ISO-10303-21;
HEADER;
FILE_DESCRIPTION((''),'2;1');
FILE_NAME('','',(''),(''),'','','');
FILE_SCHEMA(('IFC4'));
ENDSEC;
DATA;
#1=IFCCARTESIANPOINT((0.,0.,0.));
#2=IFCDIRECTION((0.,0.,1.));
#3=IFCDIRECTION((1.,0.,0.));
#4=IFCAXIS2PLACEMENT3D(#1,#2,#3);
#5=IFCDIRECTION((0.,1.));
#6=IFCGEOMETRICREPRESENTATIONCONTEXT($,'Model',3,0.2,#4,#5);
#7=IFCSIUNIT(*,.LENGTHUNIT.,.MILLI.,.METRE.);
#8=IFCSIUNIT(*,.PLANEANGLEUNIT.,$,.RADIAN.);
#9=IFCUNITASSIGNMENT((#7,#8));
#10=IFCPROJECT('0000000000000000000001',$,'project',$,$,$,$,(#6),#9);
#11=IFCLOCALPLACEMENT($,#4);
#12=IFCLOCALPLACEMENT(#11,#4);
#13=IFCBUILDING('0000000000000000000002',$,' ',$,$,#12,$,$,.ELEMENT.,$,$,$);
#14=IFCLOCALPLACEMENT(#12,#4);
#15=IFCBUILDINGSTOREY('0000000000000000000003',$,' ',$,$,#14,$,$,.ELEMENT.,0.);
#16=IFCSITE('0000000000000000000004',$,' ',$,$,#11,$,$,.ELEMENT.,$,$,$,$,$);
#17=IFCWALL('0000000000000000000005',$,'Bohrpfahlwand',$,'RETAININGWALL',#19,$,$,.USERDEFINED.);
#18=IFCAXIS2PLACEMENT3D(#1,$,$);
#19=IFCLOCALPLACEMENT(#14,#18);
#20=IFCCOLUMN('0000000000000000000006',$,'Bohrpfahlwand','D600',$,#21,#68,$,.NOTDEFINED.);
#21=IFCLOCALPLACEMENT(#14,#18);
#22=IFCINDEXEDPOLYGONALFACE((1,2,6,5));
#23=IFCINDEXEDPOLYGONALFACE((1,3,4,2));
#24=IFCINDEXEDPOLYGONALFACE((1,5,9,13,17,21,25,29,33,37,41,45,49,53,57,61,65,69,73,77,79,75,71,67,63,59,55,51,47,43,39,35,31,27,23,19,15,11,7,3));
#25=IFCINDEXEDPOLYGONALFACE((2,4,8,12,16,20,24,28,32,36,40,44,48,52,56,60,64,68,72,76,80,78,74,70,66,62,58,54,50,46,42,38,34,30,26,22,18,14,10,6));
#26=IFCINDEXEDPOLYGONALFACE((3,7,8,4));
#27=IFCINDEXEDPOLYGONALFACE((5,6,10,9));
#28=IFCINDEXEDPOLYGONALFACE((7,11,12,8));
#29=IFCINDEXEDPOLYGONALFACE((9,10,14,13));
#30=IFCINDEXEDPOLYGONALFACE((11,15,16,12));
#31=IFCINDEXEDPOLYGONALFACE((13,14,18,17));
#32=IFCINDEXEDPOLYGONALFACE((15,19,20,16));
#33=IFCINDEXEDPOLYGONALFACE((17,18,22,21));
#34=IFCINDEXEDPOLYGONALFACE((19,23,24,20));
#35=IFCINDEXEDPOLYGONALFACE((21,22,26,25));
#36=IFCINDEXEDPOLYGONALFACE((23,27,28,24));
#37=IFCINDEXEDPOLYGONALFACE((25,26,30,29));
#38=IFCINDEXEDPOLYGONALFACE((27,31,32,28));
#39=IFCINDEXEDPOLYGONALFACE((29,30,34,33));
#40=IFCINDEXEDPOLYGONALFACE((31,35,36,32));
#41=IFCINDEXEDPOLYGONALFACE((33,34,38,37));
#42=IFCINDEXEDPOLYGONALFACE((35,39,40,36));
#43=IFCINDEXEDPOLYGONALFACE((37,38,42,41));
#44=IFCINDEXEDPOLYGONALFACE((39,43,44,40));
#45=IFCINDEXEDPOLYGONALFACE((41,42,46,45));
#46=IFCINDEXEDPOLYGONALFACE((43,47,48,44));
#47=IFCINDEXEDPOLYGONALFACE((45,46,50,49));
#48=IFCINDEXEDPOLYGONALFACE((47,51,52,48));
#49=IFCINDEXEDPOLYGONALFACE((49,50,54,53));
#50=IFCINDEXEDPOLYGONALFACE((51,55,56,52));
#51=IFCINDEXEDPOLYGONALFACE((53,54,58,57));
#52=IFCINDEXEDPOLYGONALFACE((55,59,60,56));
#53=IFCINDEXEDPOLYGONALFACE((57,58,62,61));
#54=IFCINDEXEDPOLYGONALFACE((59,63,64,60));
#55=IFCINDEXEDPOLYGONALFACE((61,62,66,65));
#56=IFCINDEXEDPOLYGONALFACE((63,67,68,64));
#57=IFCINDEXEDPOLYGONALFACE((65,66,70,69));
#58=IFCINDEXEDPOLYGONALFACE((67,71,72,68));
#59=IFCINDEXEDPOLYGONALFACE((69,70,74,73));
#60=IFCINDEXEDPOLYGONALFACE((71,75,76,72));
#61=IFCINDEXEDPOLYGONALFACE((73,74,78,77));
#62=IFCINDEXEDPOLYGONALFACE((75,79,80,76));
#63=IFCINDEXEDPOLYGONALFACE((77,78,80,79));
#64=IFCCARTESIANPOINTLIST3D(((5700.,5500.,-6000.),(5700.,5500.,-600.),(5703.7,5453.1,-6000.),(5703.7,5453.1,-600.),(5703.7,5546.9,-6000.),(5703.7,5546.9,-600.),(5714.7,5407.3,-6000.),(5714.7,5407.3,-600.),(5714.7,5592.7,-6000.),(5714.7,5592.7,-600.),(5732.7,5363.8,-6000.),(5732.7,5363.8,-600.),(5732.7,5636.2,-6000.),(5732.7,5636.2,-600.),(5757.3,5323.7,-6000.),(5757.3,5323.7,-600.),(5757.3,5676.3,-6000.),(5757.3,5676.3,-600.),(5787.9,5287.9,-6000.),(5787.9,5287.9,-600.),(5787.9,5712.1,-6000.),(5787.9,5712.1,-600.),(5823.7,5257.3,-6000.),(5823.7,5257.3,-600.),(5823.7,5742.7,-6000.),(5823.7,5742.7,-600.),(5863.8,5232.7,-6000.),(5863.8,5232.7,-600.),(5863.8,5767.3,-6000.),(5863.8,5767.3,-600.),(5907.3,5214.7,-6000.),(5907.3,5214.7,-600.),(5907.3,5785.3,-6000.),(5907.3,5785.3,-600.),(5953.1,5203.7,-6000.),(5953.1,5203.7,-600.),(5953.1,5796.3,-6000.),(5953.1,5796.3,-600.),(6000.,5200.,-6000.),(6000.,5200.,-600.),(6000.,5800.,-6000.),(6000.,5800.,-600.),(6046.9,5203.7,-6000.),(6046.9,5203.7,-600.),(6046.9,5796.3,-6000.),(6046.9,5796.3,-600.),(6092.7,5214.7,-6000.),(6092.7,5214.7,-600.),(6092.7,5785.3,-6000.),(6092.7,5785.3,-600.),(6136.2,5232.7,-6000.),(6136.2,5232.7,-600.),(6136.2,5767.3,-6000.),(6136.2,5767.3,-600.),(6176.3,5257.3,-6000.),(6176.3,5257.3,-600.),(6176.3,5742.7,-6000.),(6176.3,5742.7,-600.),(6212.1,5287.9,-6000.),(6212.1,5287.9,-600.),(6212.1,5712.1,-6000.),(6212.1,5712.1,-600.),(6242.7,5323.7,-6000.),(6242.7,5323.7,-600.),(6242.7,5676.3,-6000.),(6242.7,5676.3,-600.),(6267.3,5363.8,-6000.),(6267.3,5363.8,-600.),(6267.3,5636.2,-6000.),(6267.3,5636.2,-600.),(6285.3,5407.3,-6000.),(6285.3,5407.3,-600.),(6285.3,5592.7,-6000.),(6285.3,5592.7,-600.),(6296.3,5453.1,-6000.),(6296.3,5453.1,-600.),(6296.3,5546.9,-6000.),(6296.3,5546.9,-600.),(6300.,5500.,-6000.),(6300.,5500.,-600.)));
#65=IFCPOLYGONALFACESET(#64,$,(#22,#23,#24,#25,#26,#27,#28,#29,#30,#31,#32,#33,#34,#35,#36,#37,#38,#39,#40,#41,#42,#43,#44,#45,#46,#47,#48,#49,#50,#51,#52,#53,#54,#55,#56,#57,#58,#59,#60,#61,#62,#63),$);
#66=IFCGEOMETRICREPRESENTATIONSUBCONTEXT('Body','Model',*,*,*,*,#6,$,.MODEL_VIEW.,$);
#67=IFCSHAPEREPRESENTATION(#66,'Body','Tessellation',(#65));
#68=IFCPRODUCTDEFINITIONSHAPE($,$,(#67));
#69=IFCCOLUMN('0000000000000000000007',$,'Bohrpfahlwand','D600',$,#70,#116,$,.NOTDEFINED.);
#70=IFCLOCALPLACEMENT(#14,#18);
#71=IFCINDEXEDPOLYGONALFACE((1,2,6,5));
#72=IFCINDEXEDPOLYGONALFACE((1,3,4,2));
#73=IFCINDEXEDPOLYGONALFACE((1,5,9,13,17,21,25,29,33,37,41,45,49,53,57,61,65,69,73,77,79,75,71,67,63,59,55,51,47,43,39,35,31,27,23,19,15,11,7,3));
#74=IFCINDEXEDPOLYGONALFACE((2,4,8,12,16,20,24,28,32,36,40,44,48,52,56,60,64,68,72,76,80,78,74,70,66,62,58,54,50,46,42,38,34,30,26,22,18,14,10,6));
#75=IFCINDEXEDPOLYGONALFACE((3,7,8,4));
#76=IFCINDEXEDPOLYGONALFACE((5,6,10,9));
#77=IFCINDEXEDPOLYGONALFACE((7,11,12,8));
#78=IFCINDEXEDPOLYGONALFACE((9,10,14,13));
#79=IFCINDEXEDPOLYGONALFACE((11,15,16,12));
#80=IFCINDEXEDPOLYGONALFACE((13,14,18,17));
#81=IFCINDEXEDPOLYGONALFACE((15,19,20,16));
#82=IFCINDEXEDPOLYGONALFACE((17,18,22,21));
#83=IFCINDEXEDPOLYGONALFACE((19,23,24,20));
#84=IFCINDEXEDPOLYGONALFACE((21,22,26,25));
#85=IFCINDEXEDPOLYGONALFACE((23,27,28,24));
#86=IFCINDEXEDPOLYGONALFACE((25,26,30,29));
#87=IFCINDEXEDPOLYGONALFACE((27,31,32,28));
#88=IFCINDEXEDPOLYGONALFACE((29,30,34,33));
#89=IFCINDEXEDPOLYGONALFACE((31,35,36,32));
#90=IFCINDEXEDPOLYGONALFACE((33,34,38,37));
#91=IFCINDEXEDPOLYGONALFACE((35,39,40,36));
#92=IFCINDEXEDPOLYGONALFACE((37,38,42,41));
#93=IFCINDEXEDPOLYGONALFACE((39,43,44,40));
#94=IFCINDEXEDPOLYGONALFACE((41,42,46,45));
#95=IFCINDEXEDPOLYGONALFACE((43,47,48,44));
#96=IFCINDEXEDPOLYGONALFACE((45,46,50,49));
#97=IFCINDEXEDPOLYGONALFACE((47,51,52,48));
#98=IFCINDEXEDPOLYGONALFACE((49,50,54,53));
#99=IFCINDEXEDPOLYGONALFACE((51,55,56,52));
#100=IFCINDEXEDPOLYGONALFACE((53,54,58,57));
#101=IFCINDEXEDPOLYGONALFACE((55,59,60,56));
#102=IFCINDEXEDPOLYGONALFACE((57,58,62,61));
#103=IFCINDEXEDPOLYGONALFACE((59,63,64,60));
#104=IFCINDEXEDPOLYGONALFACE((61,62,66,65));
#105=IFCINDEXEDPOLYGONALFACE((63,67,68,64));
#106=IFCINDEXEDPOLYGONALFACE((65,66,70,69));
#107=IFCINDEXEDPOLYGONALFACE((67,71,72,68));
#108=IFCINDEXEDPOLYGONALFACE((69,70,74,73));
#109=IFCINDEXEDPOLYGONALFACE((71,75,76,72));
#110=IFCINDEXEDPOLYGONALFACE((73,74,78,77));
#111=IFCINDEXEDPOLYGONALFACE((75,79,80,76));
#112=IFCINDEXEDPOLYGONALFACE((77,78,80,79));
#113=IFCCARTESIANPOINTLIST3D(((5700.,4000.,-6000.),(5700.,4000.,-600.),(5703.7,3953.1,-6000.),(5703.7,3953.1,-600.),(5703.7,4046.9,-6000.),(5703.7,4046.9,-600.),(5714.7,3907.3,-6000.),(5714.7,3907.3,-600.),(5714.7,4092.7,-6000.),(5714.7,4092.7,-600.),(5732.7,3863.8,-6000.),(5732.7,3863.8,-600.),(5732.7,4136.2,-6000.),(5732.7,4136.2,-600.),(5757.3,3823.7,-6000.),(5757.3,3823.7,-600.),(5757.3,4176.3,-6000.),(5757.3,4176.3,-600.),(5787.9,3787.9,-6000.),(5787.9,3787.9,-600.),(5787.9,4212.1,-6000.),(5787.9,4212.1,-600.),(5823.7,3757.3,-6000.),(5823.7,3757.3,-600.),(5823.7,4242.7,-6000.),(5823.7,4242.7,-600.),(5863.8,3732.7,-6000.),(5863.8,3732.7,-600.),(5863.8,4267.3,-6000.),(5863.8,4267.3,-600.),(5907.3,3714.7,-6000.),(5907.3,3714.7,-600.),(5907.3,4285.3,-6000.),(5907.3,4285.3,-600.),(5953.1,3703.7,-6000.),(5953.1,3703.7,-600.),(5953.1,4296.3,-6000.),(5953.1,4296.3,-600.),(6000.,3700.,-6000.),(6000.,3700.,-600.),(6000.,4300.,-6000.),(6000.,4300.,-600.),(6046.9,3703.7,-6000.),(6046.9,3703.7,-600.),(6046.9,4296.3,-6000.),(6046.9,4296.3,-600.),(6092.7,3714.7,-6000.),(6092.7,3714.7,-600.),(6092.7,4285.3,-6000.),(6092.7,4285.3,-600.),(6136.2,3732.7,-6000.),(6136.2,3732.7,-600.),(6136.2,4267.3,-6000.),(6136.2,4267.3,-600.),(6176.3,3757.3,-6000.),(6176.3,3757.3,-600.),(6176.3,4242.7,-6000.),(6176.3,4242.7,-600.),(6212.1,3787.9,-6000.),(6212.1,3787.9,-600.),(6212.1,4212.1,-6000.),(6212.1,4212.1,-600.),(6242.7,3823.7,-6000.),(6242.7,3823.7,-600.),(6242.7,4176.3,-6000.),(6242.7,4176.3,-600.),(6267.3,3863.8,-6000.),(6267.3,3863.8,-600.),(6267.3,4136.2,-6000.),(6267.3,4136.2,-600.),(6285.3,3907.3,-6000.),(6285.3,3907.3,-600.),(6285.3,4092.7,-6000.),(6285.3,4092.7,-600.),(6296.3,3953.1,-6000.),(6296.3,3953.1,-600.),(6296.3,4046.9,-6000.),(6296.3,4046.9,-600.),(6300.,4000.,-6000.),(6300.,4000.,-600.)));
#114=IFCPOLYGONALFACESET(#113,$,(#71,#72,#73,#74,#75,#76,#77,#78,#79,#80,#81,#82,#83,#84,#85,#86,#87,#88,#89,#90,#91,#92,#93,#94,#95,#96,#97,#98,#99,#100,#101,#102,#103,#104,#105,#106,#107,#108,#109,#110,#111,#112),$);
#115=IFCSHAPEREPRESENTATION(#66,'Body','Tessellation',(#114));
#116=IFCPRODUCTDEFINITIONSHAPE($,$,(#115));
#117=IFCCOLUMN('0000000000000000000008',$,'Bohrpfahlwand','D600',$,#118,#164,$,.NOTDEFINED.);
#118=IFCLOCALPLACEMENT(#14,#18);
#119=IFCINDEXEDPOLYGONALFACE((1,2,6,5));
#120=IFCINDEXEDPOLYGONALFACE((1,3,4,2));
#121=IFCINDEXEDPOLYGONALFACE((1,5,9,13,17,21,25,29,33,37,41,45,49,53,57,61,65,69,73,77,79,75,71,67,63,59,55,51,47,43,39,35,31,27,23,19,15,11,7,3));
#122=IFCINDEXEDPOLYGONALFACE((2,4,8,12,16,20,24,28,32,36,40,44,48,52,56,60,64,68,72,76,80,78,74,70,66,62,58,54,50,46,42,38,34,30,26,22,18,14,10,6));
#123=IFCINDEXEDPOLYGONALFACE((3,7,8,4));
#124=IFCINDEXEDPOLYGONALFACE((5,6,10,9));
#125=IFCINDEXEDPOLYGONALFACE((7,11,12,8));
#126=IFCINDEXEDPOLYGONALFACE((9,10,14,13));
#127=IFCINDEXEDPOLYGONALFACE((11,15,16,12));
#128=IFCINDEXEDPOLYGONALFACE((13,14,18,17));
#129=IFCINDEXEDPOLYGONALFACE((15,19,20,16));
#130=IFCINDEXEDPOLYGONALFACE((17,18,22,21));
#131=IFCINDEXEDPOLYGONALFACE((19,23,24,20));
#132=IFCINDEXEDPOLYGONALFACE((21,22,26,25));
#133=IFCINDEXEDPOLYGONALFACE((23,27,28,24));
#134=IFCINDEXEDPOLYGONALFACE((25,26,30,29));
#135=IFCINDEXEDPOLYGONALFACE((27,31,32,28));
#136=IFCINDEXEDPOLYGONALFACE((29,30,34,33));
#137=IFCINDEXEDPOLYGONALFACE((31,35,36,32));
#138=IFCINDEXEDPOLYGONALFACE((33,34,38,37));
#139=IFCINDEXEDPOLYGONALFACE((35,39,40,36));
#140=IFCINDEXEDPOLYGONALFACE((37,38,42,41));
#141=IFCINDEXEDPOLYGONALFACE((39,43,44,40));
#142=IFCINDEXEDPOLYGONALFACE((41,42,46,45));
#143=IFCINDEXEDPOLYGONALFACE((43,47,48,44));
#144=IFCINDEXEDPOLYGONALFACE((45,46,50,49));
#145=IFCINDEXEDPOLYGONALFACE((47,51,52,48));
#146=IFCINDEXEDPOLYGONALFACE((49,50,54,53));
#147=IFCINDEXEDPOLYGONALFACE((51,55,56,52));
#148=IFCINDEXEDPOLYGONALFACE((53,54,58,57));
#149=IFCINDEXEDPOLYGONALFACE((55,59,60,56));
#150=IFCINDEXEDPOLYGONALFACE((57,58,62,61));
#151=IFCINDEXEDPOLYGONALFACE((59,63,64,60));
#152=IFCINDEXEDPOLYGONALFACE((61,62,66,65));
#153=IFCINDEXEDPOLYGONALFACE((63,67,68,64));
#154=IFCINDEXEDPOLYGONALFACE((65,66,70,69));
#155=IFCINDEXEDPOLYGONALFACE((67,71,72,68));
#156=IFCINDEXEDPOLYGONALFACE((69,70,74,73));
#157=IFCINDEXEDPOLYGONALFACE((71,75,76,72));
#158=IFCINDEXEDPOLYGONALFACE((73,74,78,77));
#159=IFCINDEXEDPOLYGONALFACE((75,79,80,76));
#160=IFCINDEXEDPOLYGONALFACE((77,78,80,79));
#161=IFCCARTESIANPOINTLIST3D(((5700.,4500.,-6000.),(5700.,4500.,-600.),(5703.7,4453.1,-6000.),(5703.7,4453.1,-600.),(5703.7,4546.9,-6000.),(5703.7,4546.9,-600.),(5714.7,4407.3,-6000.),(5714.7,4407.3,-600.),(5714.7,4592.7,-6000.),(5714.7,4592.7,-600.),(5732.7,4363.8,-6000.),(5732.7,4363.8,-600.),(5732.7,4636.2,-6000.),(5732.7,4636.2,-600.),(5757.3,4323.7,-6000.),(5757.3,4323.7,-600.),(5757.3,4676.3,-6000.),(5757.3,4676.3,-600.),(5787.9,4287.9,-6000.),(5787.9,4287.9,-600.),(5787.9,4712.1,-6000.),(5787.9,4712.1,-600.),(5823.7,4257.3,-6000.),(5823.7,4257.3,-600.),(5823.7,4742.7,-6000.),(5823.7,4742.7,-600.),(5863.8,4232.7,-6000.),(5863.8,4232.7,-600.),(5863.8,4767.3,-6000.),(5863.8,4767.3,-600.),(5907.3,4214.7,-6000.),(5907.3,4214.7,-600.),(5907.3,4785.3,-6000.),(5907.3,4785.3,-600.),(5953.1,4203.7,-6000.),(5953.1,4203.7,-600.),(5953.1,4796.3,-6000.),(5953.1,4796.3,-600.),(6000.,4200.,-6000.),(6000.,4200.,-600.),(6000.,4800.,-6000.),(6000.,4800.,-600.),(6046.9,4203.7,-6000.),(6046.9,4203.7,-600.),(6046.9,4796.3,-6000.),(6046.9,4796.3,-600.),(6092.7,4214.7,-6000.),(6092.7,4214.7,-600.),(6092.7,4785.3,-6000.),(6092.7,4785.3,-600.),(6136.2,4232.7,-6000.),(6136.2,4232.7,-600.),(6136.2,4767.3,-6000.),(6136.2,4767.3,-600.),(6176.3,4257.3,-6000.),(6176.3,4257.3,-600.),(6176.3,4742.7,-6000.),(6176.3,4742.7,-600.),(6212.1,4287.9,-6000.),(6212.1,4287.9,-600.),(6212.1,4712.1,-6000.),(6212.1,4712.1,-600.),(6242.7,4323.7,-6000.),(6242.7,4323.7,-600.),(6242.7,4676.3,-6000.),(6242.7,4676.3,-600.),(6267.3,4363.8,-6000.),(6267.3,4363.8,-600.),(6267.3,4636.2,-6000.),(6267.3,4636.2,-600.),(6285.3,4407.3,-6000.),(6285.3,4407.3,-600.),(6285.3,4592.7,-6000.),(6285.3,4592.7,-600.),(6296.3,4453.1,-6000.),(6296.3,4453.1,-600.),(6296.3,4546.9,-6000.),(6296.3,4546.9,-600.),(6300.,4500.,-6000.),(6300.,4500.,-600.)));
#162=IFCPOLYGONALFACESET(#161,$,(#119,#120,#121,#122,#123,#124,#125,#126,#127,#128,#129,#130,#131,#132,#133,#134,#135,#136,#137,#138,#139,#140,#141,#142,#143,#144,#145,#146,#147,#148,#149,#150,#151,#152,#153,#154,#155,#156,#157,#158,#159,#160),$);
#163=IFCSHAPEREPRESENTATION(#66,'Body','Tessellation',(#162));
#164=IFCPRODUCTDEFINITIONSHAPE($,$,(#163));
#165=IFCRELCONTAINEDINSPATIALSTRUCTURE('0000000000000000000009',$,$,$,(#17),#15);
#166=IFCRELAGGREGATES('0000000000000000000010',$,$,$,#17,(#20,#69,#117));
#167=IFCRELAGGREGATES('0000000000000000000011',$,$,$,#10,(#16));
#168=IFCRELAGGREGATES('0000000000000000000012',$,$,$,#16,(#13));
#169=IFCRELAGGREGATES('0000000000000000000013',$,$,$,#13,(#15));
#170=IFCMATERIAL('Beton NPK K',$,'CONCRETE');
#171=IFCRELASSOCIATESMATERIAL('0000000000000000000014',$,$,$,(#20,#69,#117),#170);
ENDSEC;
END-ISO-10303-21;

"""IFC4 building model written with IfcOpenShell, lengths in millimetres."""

from ifc_helpers import new_model, si_unit, direction, frame, origin_with_axes, place, context, subcontext, project, spatial, line, indexed_curve, outline, extrude, material, element, aggregate, save


model = new_model("IFC4")

# Units and contexts
model_context = context("Model", 3, precision=0.2, world=origin_with_axes(), true_north=direction((0.0, 1.0)))
body_context = subcontext(model_context, "Body", "Model", "MODEL_VIEW")
ifc_project = project(units=[si_unit("LENGTHUNIT", "METRE", prefix="MILLI"), si_unit("PLANEANGLEUNIT", "RADIAN")], contexts=[model_context])

# Site, building, storey
site_placement = place(None, origin_with_axes())
site = spatial("IfcSite", under=ifc_project, at=site_placement, Name=" ", CompositionType="ELEMENT")
building_placement = place(site_placement, origin_with_axes())
building = spatial("IfcBuilding", under=site, at=building_placement, Name=" ", CompositionType="ELEMENT")
storey_placement = place(building_placement, origin_with_axes())
storey = spatial("IfcBuildingStorey", under=building, at=storey_placement, Name=" ", CompositionType="ELEMENT", Elevation=0.0)

# Wall, columns
wall_1_placement = place(storey_placement, frame((6000.0, 5000.0, -6000.0), z_axis=(-1.0, 0.0, 0.0), x_axis=(0.0, 0.0, 1.0)))
wall_1 = element("IfcWall", 1, at=wall_1_placement, inside=storey, Name="Bohrpfahlwand", ObjectType="RETAININGWALL", PredefinedType="USERDEFINED")
ifc_material_1 = material(Name="Beton NPK K", Category="CONCRETE")
column_1_placement = place(wall_1_placement, frame((0.0, 500.0, 0.0), z_axis=(0.0, 0.0, 1.0), x_axis=(1.0, 0.0, 0.0)))
column_1 = element("IfcColumn", 2, at=column_1_placement, material=ifc_material_1, Name="Bohrpfahlwand", Description="D600", PredefinedType="NOTDEFINED", context=body_context, shape_type="SolidModel", body=[
    extrude(outline(indexed_curve([(300.0, 0.0), (296.3, 46.9), (285.3, 92.7), (267.3, 136.2), (242.7, 176.3), (212.1, 212.1), (176.3, 242.7), (136.2, 267.3), (92.7, 285.3), (46.9, 296.3), (0.0, 300.0), (-46.9, 296.3), (-92.7, 285.3), (-136.2, 267.3), (-176.3, 242.7), (-212.1, 212.1), (-242.7, 176.3), (-267.3, 136.2), (-285.3, 92.7), (-296.3, 46.9), (-300.0, 0.0), (-296.3, -46.9), (-285.3, -92.7), (-267.3, -136.2), (-242.7, -176.3), (-212.1, -212.1), (-176.3, -242.7), (-136.2, -267.3), (-92.7, -285.3), (-46.9, -296.3), (0.0, -300.0), (46.9, -296.3), (92.7, -285.3), (136.2, -267.3), (176.3, -242.7), (212.1, -212.1), (242.7, -176.3), (267.3, -136.2), (285.3, -92.7), (296.3, -46.9)], segments=[line(1, 2, 3, 4, 5, 6, 7, 8, 9, 10, 11, 12, 13, 14, 15, 16, 17, 18, 19, 20, 21, 22, 23, 24, 25, 26, 27, 28, 29, 30, 31, 32, 33, 34, 35, 36, 37, 38, 39, 40, 1)])), frame((0.0, 0.0, 0.0), z_axis=(-1.0, 0.0, 0.0), x_axis=(0.0, 0.0, 1.0)), (0.0, 0.0, -1.0), 5400.0),
])
column_2_placement = place(wall_1_placement, frame((0.0, -1000.0, 0.0), z_axis=(0.0, 0.0, 1.0), x_axis=(1.0, 0.0, 0.0)))
column_2 = element("IfcColumn", 3, at=column_2_placement, material=ifc_material_1, Name="Bohrpfahlwand", Description="D600", PredefinedType="NOTDEFINED", context=body_context, shape_type="SolidModel", body=[
    extrude(outline(indexed_curve([(300.0, 0.0), (296.3, 46.9), (285.3, 92.7), (267.3, 136.2), (242.7, 176.3), (212.1, 212.1), (176.3, 242.7), (136.2, 267.3), (92.7, 285.3), (46.9, 296.3), (0.0, 300.0), (-46.9, 296.3), (-92.7, 285.3), (-136.2, 267.3), (-176.3, 242.7), (-212.1, 212.1), (-242.7, 176.3), (-267.3, 136.2), (-285.3, 92.7), (-296.3, 46.9), (-300.0, 0.0), (-296.3, -46.9), (-285.3, -92.7), (-267.3, -136.2), (-242.7, -176.3), (-212.1, -212.1), (-176.3, -242.7), (-136.2, -267.3), (-92.7, -285.3), (-46.9, -296.3), (0.0, -300.0), (46.9, -296.3), (92.7, -285.3), (136.2, -267.3), (176.3, -242.7), (212.1, -212.1), (242.7, -176.3), (267.3, -136.2), (285.3, -92.7), (296.3, -46.9)], segments=[line(1, 2, 3, 4, 5, 6, 7, 8, 9, 10, 11, 12, 13, 14, 15, 16, 17, 18, 19, 20, 21, 22, 23, 24, 25, 26, 27, 28, 29, 30, 31, 32, 33, 34, 35, 36, 37, 38, 39, 40, 1)])), frame((0.0, 0.0, 0.0), z_axis=(-1.0, 0.0, 0.0), x_axis=(0.0, 0.0, 1.0)), (0.0, 0.0, -1.0), 5400.0),
])
column_3_placement = place(wall_1_placement, frame((0.0, -500.0, 0.0), z_axis=(0.0, 0.0, 1.0), x_axis=(1.0, 0.0, 0.0)))
column_3 = element("IfcColumn", 4, at=column_3_placement, material=ifc_material_1, Name="Bohrpfahlwand", Description="D600", PredefinedType="NOTDEFINED", context=body_context, shape_type="SolidModel", body=[
    extrude(outline(indexed_curve([(300.0, 0.0), (296.3, 46.9), (285.3, 92.7), (267.3, 136.2), (242.7, 176.3), (212.1, 212.1), (176.3, 242.7), (136.2, 267.3), (92.7, 285.3), (46.9, 296.3), (0.0, 300.0), (-46.9, 296.3), (-92.7, 285.3), (-136.2, 267.3), (-176.3, 242.7), (-212.1, 212.1), (-242.7, 176.3), (-267.3, 136.2), (-285.3, 92.7), (-296.3, 46.9), (-300.0, 0.0), (-296.3, -46.9), (-285.3, -92.7), (-267.3, -136.2), (-242.7, -176.3), (-212.1, -212.1), (-176.3, -242.7), (-136.2, -267.3), (-92.7, -285.3), (-46.9, -296.3), (0.0, -300.0), (46.9, -296.3), (92.7, -285.3), (136.2, -267.3), (176.3, -242.7), (212.1, -212.1), (242.7, -176.3), (267.3, -136.2), (285.3, -92.7), (296.3, -46.9)], segments=[line(1, 2, 3, 4, 5, 6, 7, 8, 9, 10, 11, 12, 13, 14, 15, 16, 17, 18, 19, 20, 21, 22, 23, 24, 25, 26, 27, 28, 29, 30, 31, 32, 33, 34, 35, 36, 37, 38, 39, 40, 1)])), frame((0.0, 0.0, 0.0), z_axis=(-1.0, 0.0, 0.0), x_axis=(0.0, 0.0, 1.0)), (0.0, 0.0, -1.0), 5400.0),
])
aggregate(wall_1, [column_1, column_2, column_3])

save(model, "model.ifc")
